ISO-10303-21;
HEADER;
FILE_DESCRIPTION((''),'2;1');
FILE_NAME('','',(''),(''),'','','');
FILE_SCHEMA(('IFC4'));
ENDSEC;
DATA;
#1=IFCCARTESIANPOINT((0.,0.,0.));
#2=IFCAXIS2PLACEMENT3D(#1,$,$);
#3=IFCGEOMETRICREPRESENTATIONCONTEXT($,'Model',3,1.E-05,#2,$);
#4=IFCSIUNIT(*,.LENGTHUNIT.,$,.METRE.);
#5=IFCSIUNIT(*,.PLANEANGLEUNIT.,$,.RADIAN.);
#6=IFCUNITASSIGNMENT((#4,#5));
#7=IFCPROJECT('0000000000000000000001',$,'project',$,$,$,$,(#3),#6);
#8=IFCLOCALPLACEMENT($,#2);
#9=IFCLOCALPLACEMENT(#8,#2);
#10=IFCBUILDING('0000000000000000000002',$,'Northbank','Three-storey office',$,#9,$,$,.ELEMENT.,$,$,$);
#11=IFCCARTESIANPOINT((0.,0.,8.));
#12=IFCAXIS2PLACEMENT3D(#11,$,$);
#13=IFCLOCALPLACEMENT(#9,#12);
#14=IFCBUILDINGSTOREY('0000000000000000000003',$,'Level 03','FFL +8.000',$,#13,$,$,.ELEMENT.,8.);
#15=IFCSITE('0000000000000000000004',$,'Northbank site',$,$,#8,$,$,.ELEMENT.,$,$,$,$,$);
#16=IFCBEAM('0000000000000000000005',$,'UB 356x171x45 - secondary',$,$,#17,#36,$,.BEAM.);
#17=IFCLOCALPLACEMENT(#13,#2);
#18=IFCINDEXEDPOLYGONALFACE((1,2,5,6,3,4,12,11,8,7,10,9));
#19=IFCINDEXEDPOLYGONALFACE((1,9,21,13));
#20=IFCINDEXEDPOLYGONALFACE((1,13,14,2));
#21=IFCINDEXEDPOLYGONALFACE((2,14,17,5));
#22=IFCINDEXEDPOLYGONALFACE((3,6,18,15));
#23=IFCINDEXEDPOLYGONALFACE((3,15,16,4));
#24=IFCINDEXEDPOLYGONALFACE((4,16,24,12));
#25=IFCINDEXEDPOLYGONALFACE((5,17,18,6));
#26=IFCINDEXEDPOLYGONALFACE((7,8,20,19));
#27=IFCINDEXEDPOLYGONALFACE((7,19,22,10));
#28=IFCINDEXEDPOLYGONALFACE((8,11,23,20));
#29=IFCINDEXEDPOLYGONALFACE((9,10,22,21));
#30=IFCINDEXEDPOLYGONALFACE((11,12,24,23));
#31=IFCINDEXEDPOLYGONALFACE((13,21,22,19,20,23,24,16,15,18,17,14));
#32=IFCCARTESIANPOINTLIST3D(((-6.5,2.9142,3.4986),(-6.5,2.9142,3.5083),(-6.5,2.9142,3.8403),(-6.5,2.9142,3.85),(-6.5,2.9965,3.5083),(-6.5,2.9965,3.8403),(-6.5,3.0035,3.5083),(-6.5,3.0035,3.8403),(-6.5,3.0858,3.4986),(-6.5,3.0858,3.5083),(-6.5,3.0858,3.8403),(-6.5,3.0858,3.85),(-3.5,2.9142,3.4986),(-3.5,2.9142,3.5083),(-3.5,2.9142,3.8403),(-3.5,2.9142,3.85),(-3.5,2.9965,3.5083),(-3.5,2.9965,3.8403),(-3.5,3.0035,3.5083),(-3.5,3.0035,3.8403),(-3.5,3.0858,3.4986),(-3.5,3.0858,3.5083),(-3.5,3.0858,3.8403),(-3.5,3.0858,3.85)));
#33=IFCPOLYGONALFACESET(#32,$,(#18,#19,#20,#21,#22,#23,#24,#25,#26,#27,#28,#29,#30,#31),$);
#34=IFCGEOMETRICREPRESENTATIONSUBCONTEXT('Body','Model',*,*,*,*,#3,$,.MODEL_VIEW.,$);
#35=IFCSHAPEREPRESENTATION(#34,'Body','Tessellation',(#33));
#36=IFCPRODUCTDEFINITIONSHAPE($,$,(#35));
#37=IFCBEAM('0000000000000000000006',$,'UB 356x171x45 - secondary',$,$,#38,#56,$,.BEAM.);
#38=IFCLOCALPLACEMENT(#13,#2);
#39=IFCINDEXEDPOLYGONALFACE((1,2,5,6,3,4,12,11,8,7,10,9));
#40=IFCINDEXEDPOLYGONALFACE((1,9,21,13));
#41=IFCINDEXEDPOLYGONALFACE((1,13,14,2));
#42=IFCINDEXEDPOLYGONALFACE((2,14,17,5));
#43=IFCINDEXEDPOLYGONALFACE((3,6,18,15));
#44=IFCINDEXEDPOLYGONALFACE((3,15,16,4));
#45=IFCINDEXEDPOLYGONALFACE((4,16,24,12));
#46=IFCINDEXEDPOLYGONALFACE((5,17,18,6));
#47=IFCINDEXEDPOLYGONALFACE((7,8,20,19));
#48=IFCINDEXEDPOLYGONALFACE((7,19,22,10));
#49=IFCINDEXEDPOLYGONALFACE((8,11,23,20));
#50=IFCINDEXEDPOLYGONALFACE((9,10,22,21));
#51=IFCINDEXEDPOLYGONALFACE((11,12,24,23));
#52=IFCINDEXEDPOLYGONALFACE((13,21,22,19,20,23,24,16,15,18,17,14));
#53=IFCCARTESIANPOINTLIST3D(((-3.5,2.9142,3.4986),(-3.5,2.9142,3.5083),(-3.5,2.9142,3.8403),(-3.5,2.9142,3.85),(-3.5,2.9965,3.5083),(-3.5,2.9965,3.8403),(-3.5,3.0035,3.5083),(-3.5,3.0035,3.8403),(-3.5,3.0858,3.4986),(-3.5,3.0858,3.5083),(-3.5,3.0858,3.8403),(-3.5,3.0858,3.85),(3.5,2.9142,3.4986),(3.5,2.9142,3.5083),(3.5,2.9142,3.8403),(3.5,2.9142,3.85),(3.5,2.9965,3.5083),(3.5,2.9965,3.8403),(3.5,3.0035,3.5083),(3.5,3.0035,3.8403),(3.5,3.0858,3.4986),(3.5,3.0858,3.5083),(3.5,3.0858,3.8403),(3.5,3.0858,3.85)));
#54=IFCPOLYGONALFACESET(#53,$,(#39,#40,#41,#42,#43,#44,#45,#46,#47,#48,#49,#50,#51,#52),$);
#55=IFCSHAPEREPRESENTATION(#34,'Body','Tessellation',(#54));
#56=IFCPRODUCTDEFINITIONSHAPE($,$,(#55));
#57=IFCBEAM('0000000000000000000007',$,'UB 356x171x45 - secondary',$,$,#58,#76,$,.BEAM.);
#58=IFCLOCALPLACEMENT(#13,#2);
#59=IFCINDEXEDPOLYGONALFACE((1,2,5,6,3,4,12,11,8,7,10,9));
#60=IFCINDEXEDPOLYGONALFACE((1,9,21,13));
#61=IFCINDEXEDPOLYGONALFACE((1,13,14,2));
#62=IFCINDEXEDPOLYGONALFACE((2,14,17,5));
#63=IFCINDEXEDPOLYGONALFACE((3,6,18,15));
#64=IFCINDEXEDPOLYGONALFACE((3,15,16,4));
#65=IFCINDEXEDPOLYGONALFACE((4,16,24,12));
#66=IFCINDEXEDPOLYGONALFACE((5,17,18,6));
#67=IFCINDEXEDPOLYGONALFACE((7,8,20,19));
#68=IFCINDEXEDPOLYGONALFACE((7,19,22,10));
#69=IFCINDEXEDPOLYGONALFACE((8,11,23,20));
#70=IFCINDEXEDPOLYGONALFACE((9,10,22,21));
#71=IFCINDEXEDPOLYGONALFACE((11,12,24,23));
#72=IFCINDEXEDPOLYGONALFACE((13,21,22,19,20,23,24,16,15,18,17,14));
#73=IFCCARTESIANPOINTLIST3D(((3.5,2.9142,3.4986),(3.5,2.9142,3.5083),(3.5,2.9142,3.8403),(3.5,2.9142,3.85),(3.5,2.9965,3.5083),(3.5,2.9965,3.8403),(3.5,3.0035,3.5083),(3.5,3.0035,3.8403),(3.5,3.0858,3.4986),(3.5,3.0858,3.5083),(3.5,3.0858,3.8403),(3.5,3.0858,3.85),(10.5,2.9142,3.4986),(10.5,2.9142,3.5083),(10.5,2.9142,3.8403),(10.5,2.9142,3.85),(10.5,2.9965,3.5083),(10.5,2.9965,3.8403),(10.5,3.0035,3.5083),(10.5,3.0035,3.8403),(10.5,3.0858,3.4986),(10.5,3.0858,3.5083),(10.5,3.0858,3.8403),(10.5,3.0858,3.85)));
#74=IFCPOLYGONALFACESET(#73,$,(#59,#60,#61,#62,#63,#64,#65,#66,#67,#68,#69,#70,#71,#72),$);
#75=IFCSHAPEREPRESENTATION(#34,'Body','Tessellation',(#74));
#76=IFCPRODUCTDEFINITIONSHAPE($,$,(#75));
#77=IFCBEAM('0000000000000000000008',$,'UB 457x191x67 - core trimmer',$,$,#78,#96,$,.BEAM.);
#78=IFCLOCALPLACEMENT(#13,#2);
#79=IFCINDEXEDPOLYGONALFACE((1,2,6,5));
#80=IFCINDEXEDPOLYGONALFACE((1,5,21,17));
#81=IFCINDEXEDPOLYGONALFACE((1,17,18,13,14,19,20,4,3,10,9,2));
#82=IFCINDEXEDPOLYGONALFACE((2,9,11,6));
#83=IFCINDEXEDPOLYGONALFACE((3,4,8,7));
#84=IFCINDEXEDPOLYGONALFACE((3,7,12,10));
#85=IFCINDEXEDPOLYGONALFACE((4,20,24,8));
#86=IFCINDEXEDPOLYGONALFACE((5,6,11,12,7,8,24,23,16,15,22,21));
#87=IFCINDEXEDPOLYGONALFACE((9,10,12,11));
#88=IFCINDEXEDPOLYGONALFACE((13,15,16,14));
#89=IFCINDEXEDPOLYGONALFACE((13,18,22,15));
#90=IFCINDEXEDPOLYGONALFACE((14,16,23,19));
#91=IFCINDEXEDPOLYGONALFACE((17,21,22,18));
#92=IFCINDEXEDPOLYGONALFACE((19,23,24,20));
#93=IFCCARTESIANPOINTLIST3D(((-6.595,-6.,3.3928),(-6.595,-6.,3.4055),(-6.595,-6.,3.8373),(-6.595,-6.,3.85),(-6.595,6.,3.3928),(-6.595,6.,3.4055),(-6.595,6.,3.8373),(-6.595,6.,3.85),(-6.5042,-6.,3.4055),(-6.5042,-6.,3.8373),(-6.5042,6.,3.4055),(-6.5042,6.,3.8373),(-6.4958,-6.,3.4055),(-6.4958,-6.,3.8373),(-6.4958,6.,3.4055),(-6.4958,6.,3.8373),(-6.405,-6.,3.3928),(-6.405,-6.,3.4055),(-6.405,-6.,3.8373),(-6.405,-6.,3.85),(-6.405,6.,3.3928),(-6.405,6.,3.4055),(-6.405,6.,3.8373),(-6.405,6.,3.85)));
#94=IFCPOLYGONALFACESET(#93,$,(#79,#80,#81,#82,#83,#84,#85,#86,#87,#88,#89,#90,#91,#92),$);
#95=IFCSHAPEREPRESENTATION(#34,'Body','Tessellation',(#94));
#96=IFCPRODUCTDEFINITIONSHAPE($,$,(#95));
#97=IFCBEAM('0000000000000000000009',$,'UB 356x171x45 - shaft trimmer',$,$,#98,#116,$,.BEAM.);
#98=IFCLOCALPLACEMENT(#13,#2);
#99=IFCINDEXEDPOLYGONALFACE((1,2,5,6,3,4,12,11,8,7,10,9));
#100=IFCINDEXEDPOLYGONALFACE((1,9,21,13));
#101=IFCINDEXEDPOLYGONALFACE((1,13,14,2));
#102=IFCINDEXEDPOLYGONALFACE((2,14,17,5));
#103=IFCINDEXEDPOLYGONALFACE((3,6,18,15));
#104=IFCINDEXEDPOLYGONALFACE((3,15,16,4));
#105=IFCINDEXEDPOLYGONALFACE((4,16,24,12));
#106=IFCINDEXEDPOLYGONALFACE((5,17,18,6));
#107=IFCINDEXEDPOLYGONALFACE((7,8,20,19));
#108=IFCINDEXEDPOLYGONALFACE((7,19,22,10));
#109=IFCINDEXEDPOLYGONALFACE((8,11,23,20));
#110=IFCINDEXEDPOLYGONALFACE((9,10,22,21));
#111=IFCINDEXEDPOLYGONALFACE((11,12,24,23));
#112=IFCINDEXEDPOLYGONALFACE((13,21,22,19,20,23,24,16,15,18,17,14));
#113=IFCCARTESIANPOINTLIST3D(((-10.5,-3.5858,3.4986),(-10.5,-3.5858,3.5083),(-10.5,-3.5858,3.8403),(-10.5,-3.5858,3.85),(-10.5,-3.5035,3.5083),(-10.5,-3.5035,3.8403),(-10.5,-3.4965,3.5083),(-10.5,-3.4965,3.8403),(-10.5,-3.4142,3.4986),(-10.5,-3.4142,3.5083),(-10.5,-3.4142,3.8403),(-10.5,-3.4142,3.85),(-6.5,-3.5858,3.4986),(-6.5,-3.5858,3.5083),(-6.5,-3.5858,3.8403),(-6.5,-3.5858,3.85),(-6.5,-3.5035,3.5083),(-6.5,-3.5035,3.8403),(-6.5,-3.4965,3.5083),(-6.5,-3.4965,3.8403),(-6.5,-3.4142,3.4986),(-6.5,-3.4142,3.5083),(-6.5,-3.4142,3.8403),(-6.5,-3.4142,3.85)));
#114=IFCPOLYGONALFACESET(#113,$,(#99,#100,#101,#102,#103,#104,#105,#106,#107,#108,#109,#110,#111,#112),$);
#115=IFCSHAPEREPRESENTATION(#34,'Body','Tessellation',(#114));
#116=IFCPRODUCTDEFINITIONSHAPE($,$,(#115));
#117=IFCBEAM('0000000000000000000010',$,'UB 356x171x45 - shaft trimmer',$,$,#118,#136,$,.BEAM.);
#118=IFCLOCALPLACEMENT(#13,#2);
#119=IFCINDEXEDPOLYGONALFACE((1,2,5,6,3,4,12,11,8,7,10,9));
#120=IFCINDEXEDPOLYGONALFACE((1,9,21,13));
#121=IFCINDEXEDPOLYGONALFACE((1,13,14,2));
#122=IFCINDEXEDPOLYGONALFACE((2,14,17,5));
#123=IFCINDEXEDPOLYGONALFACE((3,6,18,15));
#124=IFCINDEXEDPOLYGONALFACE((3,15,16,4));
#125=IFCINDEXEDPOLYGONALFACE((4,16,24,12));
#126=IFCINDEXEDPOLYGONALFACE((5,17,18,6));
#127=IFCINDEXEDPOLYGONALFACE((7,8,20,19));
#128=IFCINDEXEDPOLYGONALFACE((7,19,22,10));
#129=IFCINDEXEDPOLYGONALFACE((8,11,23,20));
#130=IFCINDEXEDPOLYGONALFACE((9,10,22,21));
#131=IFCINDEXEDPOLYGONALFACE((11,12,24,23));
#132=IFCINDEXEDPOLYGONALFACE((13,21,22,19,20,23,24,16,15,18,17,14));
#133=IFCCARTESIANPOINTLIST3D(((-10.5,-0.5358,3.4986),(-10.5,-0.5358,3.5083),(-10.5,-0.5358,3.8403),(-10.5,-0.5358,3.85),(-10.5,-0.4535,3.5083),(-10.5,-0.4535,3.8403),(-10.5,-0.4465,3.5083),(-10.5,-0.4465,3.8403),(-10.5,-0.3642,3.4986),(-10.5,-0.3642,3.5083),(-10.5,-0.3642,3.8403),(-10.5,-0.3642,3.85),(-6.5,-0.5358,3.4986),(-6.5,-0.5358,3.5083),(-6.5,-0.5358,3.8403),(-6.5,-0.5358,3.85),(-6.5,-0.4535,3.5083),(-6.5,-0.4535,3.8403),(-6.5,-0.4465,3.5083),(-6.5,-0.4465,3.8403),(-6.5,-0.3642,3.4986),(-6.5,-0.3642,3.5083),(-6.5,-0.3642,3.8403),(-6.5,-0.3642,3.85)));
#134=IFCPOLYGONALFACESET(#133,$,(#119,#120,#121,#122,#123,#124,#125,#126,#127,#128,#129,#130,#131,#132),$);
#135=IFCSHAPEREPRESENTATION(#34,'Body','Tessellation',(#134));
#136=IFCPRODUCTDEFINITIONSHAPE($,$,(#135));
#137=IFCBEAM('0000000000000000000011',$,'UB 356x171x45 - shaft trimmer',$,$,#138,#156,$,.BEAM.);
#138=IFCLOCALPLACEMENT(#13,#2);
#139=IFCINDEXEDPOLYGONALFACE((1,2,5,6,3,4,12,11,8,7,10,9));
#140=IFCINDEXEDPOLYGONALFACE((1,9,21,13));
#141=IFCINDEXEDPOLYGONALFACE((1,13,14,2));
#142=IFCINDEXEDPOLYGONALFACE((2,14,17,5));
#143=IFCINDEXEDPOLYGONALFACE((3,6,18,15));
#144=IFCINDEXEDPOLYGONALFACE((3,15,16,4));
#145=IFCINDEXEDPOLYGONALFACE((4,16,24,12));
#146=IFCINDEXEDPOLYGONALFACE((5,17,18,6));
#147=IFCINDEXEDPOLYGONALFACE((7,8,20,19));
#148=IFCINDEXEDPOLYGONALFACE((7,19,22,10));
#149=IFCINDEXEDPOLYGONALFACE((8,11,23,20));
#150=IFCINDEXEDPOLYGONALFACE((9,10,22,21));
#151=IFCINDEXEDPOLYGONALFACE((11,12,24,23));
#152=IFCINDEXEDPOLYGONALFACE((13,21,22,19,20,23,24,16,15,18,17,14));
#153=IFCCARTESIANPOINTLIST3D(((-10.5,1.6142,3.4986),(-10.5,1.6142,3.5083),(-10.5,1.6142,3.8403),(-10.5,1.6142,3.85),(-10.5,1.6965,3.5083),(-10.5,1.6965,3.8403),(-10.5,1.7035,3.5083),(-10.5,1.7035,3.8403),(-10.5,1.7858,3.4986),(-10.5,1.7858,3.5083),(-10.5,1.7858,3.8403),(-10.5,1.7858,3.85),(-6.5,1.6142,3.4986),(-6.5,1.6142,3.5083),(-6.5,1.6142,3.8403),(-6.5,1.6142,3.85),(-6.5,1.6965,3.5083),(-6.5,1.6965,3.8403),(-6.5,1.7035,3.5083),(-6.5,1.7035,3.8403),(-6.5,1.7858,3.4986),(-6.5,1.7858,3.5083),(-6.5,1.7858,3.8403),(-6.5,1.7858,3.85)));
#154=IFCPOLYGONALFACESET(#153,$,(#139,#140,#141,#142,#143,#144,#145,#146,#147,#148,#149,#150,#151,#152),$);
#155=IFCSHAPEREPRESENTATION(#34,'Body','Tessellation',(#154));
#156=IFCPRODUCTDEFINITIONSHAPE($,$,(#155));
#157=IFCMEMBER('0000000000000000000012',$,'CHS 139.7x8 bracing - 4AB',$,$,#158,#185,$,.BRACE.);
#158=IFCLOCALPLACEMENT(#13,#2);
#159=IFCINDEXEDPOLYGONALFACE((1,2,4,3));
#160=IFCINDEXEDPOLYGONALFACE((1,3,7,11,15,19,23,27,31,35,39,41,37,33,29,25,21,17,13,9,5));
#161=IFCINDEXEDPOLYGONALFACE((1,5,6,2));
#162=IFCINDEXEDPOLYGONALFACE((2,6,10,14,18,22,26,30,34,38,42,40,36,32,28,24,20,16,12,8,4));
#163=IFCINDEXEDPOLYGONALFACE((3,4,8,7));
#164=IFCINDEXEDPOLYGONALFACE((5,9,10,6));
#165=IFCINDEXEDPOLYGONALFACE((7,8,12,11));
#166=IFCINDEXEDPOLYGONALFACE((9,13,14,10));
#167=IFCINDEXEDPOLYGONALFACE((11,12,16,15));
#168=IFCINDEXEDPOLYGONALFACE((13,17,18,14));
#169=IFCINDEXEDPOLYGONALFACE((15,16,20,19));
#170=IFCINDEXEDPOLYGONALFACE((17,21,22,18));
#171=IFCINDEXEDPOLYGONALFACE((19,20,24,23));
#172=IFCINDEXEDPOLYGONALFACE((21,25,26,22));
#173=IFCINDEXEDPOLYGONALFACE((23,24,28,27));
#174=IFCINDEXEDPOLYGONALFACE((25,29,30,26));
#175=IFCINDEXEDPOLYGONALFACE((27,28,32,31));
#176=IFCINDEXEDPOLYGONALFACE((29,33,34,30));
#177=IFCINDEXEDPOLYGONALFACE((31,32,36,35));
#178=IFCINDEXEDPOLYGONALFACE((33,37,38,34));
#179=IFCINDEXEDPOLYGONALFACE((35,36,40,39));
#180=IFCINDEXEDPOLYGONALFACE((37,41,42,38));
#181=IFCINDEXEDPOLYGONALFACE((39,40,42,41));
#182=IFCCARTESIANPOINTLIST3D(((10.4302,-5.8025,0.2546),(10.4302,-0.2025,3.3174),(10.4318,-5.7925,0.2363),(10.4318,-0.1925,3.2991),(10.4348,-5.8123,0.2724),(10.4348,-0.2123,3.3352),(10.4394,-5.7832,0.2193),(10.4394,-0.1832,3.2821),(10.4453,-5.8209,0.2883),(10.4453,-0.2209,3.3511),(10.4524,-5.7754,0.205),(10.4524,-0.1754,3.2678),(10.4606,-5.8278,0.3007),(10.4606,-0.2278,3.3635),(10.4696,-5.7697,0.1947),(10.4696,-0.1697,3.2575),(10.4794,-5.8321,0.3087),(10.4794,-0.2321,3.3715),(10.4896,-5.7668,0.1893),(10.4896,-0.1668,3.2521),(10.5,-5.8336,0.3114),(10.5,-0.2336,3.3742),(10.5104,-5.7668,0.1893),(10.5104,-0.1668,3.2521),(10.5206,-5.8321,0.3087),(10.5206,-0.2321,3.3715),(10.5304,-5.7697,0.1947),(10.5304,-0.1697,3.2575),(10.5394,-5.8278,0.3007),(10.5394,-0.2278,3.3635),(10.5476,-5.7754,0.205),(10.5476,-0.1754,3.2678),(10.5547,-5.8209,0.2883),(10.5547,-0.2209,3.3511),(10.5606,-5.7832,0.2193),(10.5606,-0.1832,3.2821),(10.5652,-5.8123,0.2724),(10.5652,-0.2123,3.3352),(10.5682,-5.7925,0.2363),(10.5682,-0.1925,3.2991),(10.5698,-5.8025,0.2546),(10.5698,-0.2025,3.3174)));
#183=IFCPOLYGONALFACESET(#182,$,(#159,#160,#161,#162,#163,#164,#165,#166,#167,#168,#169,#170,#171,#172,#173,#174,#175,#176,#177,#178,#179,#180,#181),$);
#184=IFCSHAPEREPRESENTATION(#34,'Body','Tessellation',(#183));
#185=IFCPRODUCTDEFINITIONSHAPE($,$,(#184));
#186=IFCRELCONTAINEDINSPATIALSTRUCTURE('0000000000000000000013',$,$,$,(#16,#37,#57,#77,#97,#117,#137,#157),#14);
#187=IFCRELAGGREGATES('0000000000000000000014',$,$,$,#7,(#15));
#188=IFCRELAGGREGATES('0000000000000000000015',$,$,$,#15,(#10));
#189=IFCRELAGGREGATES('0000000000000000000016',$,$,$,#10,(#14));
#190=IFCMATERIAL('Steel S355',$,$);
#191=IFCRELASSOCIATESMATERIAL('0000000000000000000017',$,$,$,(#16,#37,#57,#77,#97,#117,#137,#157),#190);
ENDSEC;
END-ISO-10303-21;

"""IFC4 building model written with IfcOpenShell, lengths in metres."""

from ifc_helpers import new_model, si_unit, frame, origin, place, context, subcontext, project, spatial, circle, i_section, extrude, material, element, save


model = new_model("IFC4")

# Units and contexts
model_context = context("Model", 3, precision=1e-05, world=origin())
body_context = subcontext(model_context, "Body", "Model", "MODEL_VIEW")
ifc_project = project(units=[si_unit("LENGTHUNIT", "METRE"), si_unit("PLANEANGLEUNIT", "RADIAN")], contexts=[model_context])

# Site, building, storey
site_placement = place(None, origin())
site = spatial("IfcSite", under=ifc_project, at=site_placement, Name="Northbank site", CompositionType="ELEMENT")
building_placement = place(site_placement, origin())
building = spatial("IfcBuilding", under=site, at=building_placement, Name="Northbank", Description="Three-storey office", CompositionType="ELEMENT")
storey_placement = place(building_placement, frame((0.0, 0.0, 8.0)))
storey = spatial("IfcBuildingStorey", under=building, at=storey_placement, Name="Level 03", Description="FFL +8.000", CompositionType="ELEMENT", Elevation=8.0)

# Beams
ifc_material_1 = material(Name="Steel S355")
beam_1_placement = place(storey_placement, frame((0.0, 0.0, -8.0)))
element("IfcBeam", 1, at=beam_1_placement, inside=storey, material=ifc_material_1, Name="UB 356x171x45 - secondary", PredefinedType="BEAM", context=body_context, shape_type="SweptSolid", body=[
    extrude(i_section(OverallWidth=0.1715, OverallDepth=0.3514, WebThickness=0.007, FlangeThickness=0.0097), frame((-6.5, 3.0, 11.6743), z_axis=(1.0, 0.0, 0.0), x_axis=(0.0, 1.0, 0.0)), (0.0, 0.0, 1.0), 3.0),
])
beam_2_placement = place(storey_placement, frame((0.0, 0.0, -8.0)))
element("IfcBeam", 2, at=beam_2_placement, inside=storey, material=ifc_material_1, Name="UB 356x171x45 - secondary", PredefinedType="BEAM", context=body_context, shape_type="SweptSolid", body=[
    extrude(i_section(OverallWidth=0.1715, OverallDepth=0.3514, WebThickness=0.007, FlangeThickness=0.0097), frame((-3.5, 3.0, 11.6743), z_axis=(1.0, 0.0, 0.0), x_axis=(0.0, 1.0, 0.0)), (0.0, 0.0, 1.0), 7.0),
])
beam_3_placement = place(storey_placement, frame((0.0, 0.0, -8.0)))
element("IfcBeam", 3, at=beam_3_placement, inside=storey, material=ifc_material_1, Name="UB 356x171x45 - secondary", PredefinedType="BEAM", context=body_context, shape_type="SweptSolid", body=[
    extrude(i_section(OverallWidth=0.1715, OverallDepth=0.3514, WebThickness=0.007, FlangeThickness=0.0097), frame((3.5, 3.0, 11.6743), z_axis=(1.0, 0.0, 0.0), x_axis=(0.0, 1.0, 0.0)), (0.0, 0.0, 1.0), 7.0),
])
beam_4_placement = place(storey_placement, frame((0.0, 0.0, -8.0)))
element("IfcBeam", 4, at=beam_4_placement, inside=storey, material=ifc_material_1, Name="UB 457x191x67 - core trimmer", PredefinedType="BEAM", context=body_context, shape_type="SweptSolid", body=[
    extrude(i_section(OverallWidth=0.1899, OverallDepth=0.4572, WebThickness=0.0085, FlangeThickness=0.0127), frame((-6.5, -6.0, 11.6214), z_axis=(0.0, 1.0, 0.0), x_axis=(-1.0, 0.0, 0.0)), (0.0, 0.0, 1.0), 12.0),
])
beam_5_placement = place(storey_placement, frame((0.0, 0.0, -8.0)))
element("IfcBeam", 5, at=beam_5_placement, inside=storey, material=ifc_material_1, Name="UB 356x171x45 - shaft trimmer", PredefinedType="BEAM", context=body_context, shape_type="SweptSolid", body=[
    extrude(i_section(OverallWidth=0.1715, OverallDepth=0.3514, WebThickness=0.007, FlangeThickness=0.0097), frame((-10.5, -3.5, 11.6743), z_axis=(1.0, 0.0, 0.0), x_axis=(0.0, 1.0, 0.0)), (0.0, 0.0, 1.0), 4.0),
])
beam_6_placement = place(storey_placement, frame((0.0, 0.0, -8.0)))
element("IfcBeam", 6, at=beam_6_placement, inside=storey, material=ifc_material_1, Name="UB 356x171x45 - shaft trimmer", PredefinedType="BEAM", context=body_context, shape_type="SweptSolid", body=[
    extrude(i_section(OverallWidth=0.1715, OverallDepth=0.3514, WebThickness=0.007, FlangeThickness=0.0097), frame((-10.5, -0.45, 11.6743), z_axis=(1.0, 0.0, 0.0), x_axis=(0.0, 1.0, 0.0)), (0.0, 0.0, 1.0), 4.0),
])
beam_7_placement = place(storey_placement, frame((0.0, 0.0, -8.0)))
element("IfcBeam", 7, at=beam_7_placement, inside=storey, material=ifc_material_1, Name="UB 356x171x45 - shaft trimmer", PredefinedType="BEAM", context=body_context, shape_type="SweptSolid", body=[
    extrude(i_section(OverallWidth=0.1715, OverallDepth=0.3514, WebThickness=0.007, FlangeThickness=0.0097), frame((-10.5, 1.7, 11.6743), z_axis=(1.0, 0.0, 0.0), x_axis=(0.0, 1.0, 0.0)), (0.0, 0.0, 1.0), 4.0),
])

# Member
member_1_placement = place(storey_placement, frame((0.0, 0.0, -8.0)))
element("IfcMember", 8, at=member_1_placement, inside=storey, material=ifc_material_1, Name="CHS 139.7x8 bracing - 4AB", PredefinedType="BRACE", context=body_context, shape_type="SweptSolid", body=[
    extrude(circle(Radius=0.07), frame((10.5, -5.8, 8.25), z_axis=(0.0, 0.877351, 0.479849), x_axis=(0.0, -0.479849, 0.877351)), (0.0, 0.0, 1.0), 6.3828),
])

save(model, "model.ifc")
